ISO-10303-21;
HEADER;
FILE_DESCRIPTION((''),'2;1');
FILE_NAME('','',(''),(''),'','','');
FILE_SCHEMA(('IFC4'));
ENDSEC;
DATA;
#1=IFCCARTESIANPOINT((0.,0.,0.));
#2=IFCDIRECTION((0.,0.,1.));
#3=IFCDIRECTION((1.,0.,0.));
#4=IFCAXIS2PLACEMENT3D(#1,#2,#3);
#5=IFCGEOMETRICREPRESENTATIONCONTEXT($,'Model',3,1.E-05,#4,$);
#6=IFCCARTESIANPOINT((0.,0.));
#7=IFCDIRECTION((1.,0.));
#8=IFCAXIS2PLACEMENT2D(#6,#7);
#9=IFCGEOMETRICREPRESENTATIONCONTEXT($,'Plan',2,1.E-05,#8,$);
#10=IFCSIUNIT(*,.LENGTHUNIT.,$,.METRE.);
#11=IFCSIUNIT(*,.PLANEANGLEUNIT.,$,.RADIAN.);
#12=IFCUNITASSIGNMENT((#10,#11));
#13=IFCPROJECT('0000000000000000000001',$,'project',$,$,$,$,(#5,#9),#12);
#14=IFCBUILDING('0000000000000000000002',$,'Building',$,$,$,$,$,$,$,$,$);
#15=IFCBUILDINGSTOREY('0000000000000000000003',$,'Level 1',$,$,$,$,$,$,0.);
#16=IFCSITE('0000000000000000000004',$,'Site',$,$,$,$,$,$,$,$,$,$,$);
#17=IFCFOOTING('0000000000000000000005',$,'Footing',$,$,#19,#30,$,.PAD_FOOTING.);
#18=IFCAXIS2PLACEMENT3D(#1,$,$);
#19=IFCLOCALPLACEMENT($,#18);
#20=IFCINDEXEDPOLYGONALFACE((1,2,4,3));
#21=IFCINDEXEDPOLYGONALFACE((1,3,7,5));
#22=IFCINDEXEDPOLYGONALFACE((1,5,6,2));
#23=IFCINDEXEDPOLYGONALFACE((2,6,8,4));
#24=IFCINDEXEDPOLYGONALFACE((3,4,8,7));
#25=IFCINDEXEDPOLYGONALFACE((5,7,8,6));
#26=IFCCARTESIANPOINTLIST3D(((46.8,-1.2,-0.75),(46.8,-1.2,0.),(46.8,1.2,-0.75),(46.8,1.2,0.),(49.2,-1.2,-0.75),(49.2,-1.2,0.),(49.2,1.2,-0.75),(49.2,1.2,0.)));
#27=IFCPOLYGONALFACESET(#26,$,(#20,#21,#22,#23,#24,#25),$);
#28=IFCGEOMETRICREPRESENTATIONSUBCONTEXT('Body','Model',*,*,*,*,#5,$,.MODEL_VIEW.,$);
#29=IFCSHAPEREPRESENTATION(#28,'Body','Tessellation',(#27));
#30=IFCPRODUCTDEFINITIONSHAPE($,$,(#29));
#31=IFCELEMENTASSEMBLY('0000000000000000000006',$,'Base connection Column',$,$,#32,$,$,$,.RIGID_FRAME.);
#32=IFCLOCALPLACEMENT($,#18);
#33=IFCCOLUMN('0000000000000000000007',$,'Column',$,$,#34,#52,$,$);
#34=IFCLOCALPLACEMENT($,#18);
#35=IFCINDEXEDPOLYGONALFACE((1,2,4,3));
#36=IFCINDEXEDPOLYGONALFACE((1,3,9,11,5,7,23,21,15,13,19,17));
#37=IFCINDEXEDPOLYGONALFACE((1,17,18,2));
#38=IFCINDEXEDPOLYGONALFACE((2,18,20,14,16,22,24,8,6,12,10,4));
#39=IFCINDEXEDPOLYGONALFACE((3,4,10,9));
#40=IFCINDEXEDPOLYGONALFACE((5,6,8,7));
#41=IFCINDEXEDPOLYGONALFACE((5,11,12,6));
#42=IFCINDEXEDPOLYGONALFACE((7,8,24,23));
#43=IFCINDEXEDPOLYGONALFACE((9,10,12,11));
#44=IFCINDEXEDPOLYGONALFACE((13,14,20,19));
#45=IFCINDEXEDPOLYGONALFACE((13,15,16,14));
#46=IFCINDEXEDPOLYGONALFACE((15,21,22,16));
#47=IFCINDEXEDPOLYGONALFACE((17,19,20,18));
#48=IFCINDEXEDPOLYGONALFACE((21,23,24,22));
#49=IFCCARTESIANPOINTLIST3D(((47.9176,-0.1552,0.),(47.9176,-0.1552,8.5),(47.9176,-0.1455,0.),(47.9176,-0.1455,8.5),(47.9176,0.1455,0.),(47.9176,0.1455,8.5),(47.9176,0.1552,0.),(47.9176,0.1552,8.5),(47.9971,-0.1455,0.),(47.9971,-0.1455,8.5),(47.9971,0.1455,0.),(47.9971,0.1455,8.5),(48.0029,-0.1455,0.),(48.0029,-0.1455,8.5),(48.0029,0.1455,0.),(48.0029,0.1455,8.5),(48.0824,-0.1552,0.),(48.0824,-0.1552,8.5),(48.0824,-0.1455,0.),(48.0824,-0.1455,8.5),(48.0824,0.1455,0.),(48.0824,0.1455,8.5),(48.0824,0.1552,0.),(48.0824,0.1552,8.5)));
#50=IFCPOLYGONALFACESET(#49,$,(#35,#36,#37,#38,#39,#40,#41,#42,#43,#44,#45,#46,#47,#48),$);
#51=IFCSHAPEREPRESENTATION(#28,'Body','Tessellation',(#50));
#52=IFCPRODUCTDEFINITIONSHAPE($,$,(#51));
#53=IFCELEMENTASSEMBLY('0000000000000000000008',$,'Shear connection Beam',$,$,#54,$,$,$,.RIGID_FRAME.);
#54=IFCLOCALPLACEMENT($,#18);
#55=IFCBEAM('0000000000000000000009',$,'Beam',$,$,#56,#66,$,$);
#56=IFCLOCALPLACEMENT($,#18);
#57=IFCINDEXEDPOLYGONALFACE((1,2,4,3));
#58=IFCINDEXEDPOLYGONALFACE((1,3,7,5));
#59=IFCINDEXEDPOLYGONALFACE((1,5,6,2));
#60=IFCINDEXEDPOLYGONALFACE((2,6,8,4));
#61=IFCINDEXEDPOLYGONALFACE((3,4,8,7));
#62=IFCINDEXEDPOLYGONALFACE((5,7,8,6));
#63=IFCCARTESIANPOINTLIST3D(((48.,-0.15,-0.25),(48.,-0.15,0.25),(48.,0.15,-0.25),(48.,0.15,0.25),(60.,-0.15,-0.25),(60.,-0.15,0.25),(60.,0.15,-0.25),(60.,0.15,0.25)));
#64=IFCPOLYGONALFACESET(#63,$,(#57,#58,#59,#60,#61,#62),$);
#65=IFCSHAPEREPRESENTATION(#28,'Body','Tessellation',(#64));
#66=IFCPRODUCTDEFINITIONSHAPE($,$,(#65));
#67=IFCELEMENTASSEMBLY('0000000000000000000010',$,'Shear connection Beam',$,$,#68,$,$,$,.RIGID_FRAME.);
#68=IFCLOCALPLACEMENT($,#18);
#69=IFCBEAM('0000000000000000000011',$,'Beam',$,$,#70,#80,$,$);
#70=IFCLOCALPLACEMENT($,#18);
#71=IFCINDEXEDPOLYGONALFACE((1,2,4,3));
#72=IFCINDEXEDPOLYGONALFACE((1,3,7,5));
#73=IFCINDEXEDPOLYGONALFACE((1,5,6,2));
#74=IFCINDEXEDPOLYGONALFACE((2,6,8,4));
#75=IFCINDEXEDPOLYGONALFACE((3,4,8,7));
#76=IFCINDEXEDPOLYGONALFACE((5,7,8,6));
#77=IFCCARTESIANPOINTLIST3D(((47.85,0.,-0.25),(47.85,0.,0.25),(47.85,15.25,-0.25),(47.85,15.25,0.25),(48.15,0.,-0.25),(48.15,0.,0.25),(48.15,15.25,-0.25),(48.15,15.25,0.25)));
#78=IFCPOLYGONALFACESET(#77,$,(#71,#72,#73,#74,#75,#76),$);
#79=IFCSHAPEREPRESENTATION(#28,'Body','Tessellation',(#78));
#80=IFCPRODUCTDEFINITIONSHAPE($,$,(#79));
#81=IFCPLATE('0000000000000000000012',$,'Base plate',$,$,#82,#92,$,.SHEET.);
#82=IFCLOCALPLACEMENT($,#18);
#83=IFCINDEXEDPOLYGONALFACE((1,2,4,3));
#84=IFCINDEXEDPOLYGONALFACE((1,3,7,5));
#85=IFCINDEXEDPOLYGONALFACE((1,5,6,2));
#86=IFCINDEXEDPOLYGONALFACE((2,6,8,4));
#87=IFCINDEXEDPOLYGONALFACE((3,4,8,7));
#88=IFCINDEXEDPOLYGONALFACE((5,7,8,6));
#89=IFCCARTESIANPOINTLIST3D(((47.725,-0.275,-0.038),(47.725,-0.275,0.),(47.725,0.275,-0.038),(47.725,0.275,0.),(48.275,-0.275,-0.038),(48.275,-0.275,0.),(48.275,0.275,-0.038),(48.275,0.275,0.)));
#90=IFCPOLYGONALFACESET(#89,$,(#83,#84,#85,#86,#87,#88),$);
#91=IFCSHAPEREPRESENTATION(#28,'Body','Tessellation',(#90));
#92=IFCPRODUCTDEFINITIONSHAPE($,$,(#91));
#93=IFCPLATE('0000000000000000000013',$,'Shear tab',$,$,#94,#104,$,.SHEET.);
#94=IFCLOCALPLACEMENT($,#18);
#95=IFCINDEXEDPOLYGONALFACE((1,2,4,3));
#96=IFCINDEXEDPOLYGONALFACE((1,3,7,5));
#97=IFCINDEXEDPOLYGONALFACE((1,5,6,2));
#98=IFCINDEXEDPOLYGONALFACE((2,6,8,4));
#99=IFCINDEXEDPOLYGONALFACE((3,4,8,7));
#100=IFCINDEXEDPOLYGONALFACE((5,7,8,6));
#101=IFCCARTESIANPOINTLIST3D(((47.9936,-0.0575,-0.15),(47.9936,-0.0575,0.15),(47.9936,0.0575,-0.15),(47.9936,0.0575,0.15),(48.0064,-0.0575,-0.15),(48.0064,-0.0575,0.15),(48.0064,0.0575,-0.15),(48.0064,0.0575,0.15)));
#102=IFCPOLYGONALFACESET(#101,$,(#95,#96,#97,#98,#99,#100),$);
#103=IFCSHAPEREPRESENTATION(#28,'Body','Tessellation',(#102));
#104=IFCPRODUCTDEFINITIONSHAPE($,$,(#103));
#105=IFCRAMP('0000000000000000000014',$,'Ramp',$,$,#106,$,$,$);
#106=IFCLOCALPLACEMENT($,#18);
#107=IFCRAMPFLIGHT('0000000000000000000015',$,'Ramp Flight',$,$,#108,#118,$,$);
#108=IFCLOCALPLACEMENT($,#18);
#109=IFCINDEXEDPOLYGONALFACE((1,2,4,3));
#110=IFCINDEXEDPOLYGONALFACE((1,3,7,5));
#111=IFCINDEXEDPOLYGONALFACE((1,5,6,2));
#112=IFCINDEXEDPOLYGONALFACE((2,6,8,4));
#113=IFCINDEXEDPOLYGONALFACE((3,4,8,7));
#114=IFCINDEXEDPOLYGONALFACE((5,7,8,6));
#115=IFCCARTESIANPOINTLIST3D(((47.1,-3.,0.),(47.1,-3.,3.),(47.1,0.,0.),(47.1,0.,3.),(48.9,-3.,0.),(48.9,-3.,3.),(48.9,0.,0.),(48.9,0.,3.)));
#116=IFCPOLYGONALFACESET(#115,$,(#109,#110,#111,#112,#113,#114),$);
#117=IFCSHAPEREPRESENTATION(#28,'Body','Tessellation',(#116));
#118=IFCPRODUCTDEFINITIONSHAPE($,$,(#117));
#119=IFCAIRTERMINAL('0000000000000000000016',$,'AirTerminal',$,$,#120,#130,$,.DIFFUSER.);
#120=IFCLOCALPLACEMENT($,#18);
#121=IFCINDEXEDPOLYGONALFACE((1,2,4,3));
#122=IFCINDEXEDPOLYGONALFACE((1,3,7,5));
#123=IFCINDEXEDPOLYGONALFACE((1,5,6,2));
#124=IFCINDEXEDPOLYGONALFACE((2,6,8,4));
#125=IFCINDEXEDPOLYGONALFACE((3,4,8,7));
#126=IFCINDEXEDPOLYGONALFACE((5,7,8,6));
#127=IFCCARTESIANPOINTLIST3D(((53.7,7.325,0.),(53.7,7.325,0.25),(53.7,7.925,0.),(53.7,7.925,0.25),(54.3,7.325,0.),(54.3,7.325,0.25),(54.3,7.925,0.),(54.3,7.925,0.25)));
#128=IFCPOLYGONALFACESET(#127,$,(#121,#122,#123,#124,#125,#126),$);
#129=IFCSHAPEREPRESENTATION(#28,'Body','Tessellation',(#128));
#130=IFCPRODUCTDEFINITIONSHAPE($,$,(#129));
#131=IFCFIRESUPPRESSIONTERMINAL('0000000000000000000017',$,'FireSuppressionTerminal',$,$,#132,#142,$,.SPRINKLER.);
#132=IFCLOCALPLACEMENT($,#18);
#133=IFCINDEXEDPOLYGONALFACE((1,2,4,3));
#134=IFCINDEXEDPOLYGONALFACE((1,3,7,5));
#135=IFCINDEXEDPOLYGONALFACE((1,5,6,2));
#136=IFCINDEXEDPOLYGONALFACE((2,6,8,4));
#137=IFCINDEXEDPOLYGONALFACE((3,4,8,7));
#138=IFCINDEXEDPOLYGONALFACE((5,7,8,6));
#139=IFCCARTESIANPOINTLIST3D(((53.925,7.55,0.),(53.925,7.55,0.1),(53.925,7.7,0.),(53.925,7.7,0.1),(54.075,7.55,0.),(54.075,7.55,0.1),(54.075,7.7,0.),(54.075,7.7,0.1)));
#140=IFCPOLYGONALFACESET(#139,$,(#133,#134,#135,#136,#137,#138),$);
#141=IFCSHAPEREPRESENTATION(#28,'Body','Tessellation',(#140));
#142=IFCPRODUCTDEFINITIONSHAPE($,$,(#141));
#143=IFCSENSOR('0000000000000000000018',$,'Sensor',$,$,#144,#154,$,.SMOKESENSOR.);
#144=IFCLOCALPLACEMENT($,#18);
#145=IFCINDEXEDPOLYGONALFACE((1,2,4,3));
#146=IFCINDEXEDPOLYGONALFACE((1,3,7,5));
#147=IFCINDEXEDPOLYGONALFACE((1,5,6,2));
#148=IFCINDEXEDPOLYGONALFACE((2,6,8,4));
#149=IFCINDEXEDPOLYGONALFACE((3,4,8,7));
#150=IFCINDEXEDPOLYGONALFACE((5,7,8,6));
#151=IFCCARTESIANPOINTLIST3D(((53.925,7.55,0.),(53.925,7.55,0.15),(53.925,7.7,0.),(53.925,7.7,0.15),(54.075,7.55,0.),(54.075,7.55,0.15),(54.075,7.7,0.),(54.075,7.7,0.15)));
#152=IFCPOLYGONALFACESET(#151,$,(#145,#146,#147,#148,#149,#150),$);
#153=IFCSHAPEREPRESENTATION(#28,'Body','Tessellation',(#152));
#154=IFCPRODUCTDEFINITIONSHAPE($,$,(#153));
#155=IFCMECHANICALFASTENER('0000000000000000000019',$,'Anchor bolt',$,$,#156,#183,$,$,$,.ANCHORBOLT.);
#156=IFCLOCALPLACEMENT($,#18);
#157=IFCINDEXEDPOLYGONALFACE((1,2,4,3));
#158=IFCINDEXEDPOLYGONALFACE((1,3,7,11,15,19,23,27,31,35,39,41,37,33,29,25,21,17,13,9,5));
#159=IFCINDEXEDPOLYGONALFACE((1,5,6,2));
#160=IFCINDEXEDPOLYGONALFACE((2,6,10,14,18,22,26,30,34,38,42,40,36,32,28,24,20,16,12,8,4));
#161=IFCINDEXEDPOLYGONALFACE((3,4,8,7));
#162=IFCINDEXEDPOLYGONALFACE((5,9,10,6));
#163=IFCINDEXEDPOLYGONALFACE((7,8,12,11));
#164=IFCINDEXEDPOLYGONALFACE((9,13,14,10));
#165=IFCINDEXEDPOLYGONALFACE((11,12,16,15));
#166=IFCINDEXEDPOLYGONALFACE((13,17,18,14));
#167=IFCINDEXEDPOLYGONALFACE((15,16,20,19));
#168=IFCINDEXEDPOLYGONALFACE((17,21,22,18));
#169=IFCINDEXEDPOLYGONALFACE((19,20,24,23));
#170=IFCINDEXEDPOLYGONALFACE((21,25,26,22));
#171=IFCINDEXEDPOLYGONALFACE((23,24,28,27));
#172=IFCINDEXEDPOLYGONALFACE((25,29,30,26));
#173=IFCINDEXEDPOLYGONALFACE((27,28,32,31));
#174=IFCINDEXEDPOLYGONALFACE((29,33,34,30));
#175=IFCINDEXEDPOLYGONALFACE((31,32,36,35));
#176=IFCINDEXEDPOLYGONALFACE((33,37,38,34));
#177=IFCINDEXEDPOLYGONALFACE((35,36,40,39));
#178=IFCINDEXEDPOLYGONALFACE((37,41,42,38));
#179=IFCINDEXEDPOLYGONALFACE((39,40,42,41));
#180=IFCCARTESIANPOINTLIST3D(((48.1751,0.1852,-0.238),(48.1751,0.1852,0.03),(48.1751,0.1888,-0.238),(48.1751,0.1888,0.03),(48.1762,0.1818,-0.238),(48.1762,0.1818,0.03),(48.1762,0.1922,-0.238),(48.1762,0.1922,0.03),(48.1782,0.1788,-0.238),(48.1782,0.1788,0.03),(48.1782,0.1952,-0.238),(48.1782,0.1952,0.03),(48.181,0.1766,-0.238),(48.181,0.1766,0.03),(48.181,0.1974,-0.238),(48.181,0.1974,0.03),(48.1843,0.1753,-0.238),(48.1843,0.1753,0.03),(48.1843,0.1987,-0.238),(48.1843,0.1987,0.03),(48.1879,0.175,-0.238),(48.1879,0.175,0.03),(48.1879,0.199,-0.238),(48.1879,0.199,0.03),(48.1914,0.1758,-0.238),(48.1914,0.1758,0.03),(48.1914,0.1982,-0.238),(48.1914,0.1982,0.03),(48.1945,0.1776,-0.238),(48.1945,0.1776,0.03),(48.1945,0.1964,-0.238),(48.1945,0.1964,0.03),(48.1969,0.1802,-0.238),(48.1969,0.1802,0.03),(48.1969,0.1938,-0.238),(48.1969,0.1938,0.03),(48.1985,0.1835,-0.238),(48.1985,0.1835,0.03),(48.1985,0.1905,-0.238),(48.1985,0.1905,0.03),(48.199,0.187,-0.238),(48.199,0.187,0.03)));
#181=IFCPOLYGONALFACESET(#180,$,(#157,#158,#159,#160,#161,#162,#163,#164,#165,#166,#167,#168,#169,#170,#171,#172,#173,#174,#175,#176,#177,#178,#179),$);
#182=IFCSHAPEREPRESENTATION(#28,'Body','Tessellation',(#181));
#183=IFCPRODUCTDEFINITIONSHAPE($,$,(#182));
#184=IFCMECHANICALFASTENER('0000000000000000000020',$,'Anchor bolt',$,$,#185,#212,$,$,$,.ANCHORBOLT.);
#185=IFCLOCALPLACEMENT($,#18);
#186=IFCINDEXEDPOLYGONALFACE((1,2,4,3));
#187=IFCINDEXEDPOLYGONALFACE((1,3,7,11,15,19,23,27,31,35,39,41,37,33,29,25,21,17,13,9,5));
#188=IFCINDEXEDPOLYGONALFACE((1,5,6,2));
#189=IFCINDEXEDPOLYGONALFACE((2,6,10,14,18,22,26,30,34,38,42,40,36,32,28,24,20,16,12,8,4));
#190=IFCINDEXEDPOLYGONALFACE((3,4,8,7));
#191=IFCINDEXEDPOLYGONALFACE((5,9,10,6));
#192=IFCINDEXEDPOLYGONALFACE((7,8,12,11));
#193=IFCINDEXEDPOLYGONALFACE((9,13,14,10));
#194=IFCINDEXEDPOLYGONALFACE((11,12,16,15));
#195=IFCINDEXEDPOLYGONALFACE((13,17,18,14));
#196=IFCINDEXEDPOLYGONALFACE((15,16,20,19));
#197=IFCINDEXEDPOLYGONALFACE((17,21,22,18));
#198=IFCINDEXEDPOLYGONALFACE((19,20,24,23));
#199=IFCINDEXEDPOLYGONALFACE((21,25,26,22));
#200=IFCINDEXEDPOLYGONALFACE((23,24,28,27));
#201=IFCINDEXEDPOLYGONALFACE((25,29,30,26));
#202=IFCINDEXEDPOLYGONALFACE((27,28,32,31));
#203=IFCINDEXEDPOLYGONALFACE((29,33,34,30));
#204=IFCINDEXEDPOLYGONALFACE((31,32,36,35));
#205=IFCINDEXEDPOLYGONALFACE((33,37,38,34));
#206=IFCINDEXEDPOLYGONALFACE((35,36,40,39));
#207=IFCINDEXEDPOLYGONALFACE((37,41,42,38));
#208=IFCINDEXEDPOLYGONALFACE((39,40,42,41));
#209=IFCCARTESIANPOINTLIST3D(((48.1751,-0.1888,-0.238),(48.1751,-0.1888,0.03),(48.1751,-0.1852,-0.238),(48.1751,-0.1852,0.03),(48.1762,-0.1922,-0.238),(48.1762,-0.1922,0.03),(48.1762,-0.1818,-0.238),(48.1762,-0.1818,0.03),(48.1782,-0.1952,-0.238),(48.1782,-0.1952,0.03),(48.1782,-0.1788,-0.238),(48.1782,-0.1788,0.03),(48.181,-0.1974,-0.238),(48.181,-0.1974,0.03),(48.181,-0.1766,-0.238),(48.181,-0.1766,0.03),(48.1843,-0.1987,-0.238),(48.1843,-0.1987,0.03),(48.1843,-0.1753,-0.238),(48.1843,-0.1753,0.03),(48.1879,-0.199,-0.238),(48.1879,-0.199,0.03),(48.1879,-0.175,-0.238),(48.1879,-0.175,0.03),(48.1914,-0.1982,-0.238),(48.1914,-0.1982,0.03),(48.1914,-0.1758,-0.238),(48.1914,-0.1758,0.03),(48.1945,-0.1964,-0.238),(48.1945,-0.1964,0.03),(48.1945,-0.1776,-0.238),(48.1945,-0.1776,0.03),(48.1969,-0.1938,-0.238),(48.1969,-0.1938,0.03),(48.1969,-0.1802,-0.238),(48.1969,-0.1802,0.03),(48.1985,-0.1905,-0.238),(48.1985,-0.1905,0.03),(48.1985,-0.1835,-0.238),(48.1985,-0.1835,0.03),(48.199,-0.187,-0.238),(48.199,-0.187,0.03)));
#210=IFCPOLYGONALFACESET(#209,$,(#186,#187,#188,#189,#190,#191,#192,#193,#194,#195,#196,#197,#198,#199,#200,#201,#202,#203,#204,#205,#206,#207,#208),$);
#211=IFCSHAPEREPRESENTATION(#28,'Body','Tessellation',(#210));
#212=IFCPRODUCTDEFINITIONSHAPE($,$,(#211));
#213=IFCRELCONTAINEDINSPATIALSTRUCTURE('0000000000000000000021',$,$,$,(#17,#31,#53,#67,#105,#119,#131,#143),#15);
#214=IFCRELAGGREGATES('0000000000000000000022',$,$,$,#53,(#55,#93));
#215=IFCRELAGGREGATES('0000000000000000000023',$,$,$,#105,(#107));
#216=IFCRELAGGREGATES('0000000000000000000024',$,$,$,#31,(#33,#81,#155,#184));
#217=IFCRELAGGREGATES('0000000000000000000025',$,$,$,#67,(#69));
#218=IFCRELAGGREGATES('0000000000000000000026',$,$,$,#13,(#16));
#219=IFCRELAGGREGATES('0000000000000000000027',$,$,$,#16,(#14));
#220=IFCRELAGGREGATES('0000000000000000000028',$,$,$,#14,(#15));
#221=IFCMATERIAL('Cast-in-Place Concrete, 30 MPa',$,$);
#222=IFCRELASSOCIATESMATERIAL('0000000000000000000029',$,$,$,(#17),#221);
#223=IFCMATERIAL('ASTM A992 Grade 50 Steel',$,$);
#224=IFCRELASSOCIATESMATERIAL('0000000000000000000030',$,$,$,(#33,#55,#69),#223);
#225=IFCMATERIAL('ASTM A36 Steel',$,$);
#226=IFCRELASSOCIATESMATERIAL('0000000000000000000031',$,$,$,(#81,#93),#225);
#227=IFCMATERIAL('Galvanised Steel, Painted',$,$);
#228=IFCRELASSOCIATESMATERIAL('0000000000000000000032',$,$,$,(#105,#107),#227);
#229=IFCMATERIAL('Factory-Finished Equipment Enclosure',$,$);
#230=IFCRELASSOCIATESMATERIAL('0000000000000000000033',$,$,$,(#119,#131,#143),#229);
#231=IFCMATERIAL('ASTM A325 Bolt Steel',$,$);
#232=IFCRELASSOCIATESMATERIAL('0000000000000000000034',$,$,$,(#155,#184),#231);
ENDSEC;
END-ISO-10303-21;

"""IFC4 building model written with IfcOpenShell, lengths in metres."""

from ifc_helpers import new_model, si_unit, frame, origin_with_axes, origin_2d, origin_2d_with_axis, place, context, subcontext, project, spatial, rectangle, circle, i_section, extrude, material, element, aggregate, save


model = new_model("IFC4")

# Units and contexts
model_context = context("Model", 3, precision=1e-05, world=origin_with_axes())
plan_context = context("Plan", 2, precision=1e-05, world=origin_2d_with_axis())
body_context = subcontext(model_context, "Body", "Model", "MODEL_VIEW")
ifc_project = project(units=[si_unit("LENGTHUNIT", "METRE"), si_unit("PLANEANGLEUNIT", "RADIAN")], contexts=[model_context, plan_context])

# Site, building, storey
site = spatial("IfcSite", under=ifc_project, Name="Site")
building = spatial("IfcBuilding", under=site, Name="Building")
storey = spatial("IfcBuildingStorey", under=building, Name="Level 1", Elevation=0.0)

# Footing
ifc_material_1 = material(Name="Cast-in-Place Concrete, 30 MPa")
footing_placement = place(None, frame((48.0, 0.0, -0.75), z_axis=(0.0, 0.0, 1.0), x_axis=(1.0, 0.0, 0.0)))
element("IfcFooting", 1, at=footing_placement, inside=storey, material=ifc_material_1, Name="Footing", PredefinedType="PAD_FOOTING", context=body_context, shape_type="SweptSolid", body=[
    extrude(rectangle(XDim=2.4, YDim=2.4, at=origin_2d_with_axis()), origin_with_axes(), (0.0, 0.0, 1.0), 0.75),
])

# Element assembly, column
assembly_1 = element("IfcElementAssembly", 2, inside=storey, Name="Base connection Column", PredefinedType="RIGID_FRAME")
ifc_material_2 = material(Name="ASTM A992 Grade 50 Steel")
column_placement = place(None, frame((48.0, 0.0, 0.0), z_axis=(0.0, 0.0, 1.0), x_axis=(1.0, 0.0, 0.0)))
column = element("IfcColumn", 3, at=column_placement, material=ifc_material_2, Name="Column", context=body_context, shape_type="SweptSolid", body=[
    extrude(i_section(OverallWidth=0.1648, OverallDepth=0.3104, WebThickness=0.0058, FlangeThickness=0.0097, at=origin_2d_with_axis()), origin_with_axes(), (0.0, 0.0, 1.0), 8.5),
])

# Element assemblies, beams
assembly_2 = element("IfcElementAssembly", 4, inside=storey, Name="Shear connection Beam", PredefinedType="RIGID_FRAME")
beam_1_placement = place(None, frame((48.0, 0.0, 0.0), z_axis=(1.0, 0.0, 0.0), x_axis=(0.0, 1.0, 0.0)))
beam_1 = element("IfcBeam", 5, at=beam_1_placement, material=ifc_material_2, Name="Beam", context=body_context, shape_type="SweptSolid", body=[
    extrude(rectangle(XDim=0.3, YDim=0.5, at=origin_2d_with_axis()), origin_with_axes(), (0.0, 0.0, 1.0), 12.0),
])
assembly_3 = element("IfcElementAssembly", 6, inside=storey, Name="Shear connection Beam", PredefinedType="RIGID_FRAME")
beam_2_placement = place(None, frame((48.0, 0.0, 0.0), z_axis=(0.0, 1.0, 0.0), x_axis=(-1.0, 0.0, 0.0)))
beam_2 = element("IfcBeam", 7, at=beam_2_placement, material=ifc_material_2, Name="Beam", context=body_context, shape_type="SweptSolid", body=[
    extrude(rectangle(XDim=0.3, YDim=0.5, at=origin_2d_with_axis()), origin_with_axes(), (0.0, 0.0, 1.0), 15.25),
])

# Plates
ifc_material_3 = material(Name="ASTM A36 Steel")
plate_1_placement = place(None, frame((48.0, 0.0, -0.038), z_axis=(0.0, 0.0, 1.0), x_axis=(1.0, 0.0, 0.0)))
plate_1 = element("IfcPlate", 8, at=plate_1_placement, material=ifc_material_3, Name="Base plate", PredefinedType="SHEET", context=body_context, shape_type="SweptSolid", body=[
    extrude(rectangle(XDim=0.55, YDim=0.55, at=origin_2d_with_axis()), origin_with_axes(), (0.0, 0.0, 1.0), 0.038),
])
plate_2_placement = place(None, frame((48.0, 0.0, -0.15), z_axis=(0.0, 0.0, 1.0), x_axis=(1.0, 0.0, 0.0)))
plate_2 = element("IfcPlate", 9, at=plate_2_placement, material=ifc_material_3, Name="Shear tab", PredefinedType="SHEET", context=body_context, shape_type="SweptSolid", body=[
    extrude(rectangle(XDim=0.0127, YDim=0.115, at=origin_2d_with_axis()), origin_with_axes(), (0.0, 0.0, 1.0), 0.3),
])
aggregate(assembly_2, [beam_1, plate_2])

# Ramp, ramp flight
ifc_material_4 = material(Name="Galvanised Steel, Painted")
ramp_placement = place(None, frame((48.0, -1.5, 0.0), z_axis=(0.0, 0.0, 1.0), x_axis=(0.0, 1.0, 0.0)))
ramp = element("IfcRamp", 10, at=ramp_placement, inside=storey, material=ifc_material_4, Name="Ramp")
ramp_flight_placement = place(ramp_placement, origin_with_axes())
ramp_flight = element("IfcRampFlight", 11, at=ramp_flight_placement, material=ifc_material_4, Name="Ramp Flight", context=body_context, shape_type="SweptSolid", body=[
    extrude(rectangle(XDim=3.0, YDim=1.8, at=origin_2d_with_axis()), origin_with_axes(), (0.0, 0.0, 1.0), 3.0),
])
aggregate(ramp, [ramp_flight])

# Air terminal
ifc_material_5 = material(Name="Factory-Finished Equipment Enclosure")
air_terminal_placement = place(None, frame((54.0, 7.625, 0.0), z_axis=(0.0, 0.0, 1.0), x_axis=(1.0, 0.0, 0.0)))
element("IfcAirTerminal", 12, at=air_terminal_placement, inside=storey, material=ifc_material_5, Name="AirTerminal", PredefinedType="DIFFUSER", context=body_context, shape_type="SweptSolid", body=[
    extrude(rectangle(XDim=0.6, YDim=0.6, at=origin_2d_with_axis()), origin_with_axes(), (0.0, 0.0, 1.0), 0.25),
])

# Fire suppression terminal
fire_suppression_terminal_placement = place(None, frame((54.0, 7.625, 0.0), z_axis=(0.0, 0.0, 1.0), x_axis=(1.0, 0.0, 0.0)))
element("IfcFireSuppressionTerminal", 13, at=fire_suppression_terminal_placement, inside=storey, material=ifc_material_5, Name="FireSuppressionTerminal", PredefinedType="SPRINKLER", context=body_context, shape_type="SweptSolid", body=[
    extrude(rectangle(XDim=0.15, YDim=0.15, at=origin_2d_with_axis()), origin_with_axes(), (0.0, 0.0, 1.0), 0.1),
])

# Sensor
sensor_placement = place(None, frame((54.0, 7.625, 0.0), z_axis=(0.0, 0.0, 1.0), x_axis=(1.0, 0.0, 0.0)))
element("IfcSensor", 14, at=sensor_placement, inside=storey, material=ifc_material_5, Name="Sensor", PredefinedType="SMOKESENSOR", context=body_context, shape_type="SweptSolid", body=[
    extrude(rectangle(XDim=0.15, YDim=0.15, at=origin_2d_with_axis()), origin_with_axes(), (0.0, 0.0, 1.0), 0.15),
])

# Mechanical fasteners
ifc_material_6 = material(Name="ASTM A325 Bolt Steel")
mechanical_fastener_1_placement = place(None, frame((48.187, 0.187, -0.238), z_axis=(0.0, 0.0, 1.0), x_axis=(1.0, 0.0, 0.0)))
mechanical_fastener_1 = element("IfcMechanicalFastener", 15, at=mechanical_fastener_1_placement, material=ifc_material_6, Name="Anchor bolt", PredefinedType="ANCHORBOLT", context=body_context, shape_type="SweptSolid", body=[
    extrude(circle(Radius=0.012, at=origin_2d()), origin_with_axes(), (0.0, 0.0, 1.0), 0.268),
])
mechanical_fastener_2_placement = place(None, frame((48.187, -0.187, -0.238), z_axis=(0.0, 0.0, 1.0), x_axis=(1.0, 0.0, 0.0)))
mechanical_fastener_2 = element("IfcMechanicalFastener", 16, at=mechanical_fastener_2_placement, material=ifc_material_6, Name="Anchor bolt", PredefinedType="ANCHORBOLT", context=body_context, shape_type="SweptSolid", body=[
    extrude(circle(Radius=0.012, at=origin_2d()), origin_with_axes(), (0.0, 0.0, 1.0), 0.268),
])
aggregate(assembly_1, [column, plate_1, mechanical_fastener_1, mechanical_fastener_2])

aggregate(assembly_3, [beam_2])

save(model, "model.ifc")
